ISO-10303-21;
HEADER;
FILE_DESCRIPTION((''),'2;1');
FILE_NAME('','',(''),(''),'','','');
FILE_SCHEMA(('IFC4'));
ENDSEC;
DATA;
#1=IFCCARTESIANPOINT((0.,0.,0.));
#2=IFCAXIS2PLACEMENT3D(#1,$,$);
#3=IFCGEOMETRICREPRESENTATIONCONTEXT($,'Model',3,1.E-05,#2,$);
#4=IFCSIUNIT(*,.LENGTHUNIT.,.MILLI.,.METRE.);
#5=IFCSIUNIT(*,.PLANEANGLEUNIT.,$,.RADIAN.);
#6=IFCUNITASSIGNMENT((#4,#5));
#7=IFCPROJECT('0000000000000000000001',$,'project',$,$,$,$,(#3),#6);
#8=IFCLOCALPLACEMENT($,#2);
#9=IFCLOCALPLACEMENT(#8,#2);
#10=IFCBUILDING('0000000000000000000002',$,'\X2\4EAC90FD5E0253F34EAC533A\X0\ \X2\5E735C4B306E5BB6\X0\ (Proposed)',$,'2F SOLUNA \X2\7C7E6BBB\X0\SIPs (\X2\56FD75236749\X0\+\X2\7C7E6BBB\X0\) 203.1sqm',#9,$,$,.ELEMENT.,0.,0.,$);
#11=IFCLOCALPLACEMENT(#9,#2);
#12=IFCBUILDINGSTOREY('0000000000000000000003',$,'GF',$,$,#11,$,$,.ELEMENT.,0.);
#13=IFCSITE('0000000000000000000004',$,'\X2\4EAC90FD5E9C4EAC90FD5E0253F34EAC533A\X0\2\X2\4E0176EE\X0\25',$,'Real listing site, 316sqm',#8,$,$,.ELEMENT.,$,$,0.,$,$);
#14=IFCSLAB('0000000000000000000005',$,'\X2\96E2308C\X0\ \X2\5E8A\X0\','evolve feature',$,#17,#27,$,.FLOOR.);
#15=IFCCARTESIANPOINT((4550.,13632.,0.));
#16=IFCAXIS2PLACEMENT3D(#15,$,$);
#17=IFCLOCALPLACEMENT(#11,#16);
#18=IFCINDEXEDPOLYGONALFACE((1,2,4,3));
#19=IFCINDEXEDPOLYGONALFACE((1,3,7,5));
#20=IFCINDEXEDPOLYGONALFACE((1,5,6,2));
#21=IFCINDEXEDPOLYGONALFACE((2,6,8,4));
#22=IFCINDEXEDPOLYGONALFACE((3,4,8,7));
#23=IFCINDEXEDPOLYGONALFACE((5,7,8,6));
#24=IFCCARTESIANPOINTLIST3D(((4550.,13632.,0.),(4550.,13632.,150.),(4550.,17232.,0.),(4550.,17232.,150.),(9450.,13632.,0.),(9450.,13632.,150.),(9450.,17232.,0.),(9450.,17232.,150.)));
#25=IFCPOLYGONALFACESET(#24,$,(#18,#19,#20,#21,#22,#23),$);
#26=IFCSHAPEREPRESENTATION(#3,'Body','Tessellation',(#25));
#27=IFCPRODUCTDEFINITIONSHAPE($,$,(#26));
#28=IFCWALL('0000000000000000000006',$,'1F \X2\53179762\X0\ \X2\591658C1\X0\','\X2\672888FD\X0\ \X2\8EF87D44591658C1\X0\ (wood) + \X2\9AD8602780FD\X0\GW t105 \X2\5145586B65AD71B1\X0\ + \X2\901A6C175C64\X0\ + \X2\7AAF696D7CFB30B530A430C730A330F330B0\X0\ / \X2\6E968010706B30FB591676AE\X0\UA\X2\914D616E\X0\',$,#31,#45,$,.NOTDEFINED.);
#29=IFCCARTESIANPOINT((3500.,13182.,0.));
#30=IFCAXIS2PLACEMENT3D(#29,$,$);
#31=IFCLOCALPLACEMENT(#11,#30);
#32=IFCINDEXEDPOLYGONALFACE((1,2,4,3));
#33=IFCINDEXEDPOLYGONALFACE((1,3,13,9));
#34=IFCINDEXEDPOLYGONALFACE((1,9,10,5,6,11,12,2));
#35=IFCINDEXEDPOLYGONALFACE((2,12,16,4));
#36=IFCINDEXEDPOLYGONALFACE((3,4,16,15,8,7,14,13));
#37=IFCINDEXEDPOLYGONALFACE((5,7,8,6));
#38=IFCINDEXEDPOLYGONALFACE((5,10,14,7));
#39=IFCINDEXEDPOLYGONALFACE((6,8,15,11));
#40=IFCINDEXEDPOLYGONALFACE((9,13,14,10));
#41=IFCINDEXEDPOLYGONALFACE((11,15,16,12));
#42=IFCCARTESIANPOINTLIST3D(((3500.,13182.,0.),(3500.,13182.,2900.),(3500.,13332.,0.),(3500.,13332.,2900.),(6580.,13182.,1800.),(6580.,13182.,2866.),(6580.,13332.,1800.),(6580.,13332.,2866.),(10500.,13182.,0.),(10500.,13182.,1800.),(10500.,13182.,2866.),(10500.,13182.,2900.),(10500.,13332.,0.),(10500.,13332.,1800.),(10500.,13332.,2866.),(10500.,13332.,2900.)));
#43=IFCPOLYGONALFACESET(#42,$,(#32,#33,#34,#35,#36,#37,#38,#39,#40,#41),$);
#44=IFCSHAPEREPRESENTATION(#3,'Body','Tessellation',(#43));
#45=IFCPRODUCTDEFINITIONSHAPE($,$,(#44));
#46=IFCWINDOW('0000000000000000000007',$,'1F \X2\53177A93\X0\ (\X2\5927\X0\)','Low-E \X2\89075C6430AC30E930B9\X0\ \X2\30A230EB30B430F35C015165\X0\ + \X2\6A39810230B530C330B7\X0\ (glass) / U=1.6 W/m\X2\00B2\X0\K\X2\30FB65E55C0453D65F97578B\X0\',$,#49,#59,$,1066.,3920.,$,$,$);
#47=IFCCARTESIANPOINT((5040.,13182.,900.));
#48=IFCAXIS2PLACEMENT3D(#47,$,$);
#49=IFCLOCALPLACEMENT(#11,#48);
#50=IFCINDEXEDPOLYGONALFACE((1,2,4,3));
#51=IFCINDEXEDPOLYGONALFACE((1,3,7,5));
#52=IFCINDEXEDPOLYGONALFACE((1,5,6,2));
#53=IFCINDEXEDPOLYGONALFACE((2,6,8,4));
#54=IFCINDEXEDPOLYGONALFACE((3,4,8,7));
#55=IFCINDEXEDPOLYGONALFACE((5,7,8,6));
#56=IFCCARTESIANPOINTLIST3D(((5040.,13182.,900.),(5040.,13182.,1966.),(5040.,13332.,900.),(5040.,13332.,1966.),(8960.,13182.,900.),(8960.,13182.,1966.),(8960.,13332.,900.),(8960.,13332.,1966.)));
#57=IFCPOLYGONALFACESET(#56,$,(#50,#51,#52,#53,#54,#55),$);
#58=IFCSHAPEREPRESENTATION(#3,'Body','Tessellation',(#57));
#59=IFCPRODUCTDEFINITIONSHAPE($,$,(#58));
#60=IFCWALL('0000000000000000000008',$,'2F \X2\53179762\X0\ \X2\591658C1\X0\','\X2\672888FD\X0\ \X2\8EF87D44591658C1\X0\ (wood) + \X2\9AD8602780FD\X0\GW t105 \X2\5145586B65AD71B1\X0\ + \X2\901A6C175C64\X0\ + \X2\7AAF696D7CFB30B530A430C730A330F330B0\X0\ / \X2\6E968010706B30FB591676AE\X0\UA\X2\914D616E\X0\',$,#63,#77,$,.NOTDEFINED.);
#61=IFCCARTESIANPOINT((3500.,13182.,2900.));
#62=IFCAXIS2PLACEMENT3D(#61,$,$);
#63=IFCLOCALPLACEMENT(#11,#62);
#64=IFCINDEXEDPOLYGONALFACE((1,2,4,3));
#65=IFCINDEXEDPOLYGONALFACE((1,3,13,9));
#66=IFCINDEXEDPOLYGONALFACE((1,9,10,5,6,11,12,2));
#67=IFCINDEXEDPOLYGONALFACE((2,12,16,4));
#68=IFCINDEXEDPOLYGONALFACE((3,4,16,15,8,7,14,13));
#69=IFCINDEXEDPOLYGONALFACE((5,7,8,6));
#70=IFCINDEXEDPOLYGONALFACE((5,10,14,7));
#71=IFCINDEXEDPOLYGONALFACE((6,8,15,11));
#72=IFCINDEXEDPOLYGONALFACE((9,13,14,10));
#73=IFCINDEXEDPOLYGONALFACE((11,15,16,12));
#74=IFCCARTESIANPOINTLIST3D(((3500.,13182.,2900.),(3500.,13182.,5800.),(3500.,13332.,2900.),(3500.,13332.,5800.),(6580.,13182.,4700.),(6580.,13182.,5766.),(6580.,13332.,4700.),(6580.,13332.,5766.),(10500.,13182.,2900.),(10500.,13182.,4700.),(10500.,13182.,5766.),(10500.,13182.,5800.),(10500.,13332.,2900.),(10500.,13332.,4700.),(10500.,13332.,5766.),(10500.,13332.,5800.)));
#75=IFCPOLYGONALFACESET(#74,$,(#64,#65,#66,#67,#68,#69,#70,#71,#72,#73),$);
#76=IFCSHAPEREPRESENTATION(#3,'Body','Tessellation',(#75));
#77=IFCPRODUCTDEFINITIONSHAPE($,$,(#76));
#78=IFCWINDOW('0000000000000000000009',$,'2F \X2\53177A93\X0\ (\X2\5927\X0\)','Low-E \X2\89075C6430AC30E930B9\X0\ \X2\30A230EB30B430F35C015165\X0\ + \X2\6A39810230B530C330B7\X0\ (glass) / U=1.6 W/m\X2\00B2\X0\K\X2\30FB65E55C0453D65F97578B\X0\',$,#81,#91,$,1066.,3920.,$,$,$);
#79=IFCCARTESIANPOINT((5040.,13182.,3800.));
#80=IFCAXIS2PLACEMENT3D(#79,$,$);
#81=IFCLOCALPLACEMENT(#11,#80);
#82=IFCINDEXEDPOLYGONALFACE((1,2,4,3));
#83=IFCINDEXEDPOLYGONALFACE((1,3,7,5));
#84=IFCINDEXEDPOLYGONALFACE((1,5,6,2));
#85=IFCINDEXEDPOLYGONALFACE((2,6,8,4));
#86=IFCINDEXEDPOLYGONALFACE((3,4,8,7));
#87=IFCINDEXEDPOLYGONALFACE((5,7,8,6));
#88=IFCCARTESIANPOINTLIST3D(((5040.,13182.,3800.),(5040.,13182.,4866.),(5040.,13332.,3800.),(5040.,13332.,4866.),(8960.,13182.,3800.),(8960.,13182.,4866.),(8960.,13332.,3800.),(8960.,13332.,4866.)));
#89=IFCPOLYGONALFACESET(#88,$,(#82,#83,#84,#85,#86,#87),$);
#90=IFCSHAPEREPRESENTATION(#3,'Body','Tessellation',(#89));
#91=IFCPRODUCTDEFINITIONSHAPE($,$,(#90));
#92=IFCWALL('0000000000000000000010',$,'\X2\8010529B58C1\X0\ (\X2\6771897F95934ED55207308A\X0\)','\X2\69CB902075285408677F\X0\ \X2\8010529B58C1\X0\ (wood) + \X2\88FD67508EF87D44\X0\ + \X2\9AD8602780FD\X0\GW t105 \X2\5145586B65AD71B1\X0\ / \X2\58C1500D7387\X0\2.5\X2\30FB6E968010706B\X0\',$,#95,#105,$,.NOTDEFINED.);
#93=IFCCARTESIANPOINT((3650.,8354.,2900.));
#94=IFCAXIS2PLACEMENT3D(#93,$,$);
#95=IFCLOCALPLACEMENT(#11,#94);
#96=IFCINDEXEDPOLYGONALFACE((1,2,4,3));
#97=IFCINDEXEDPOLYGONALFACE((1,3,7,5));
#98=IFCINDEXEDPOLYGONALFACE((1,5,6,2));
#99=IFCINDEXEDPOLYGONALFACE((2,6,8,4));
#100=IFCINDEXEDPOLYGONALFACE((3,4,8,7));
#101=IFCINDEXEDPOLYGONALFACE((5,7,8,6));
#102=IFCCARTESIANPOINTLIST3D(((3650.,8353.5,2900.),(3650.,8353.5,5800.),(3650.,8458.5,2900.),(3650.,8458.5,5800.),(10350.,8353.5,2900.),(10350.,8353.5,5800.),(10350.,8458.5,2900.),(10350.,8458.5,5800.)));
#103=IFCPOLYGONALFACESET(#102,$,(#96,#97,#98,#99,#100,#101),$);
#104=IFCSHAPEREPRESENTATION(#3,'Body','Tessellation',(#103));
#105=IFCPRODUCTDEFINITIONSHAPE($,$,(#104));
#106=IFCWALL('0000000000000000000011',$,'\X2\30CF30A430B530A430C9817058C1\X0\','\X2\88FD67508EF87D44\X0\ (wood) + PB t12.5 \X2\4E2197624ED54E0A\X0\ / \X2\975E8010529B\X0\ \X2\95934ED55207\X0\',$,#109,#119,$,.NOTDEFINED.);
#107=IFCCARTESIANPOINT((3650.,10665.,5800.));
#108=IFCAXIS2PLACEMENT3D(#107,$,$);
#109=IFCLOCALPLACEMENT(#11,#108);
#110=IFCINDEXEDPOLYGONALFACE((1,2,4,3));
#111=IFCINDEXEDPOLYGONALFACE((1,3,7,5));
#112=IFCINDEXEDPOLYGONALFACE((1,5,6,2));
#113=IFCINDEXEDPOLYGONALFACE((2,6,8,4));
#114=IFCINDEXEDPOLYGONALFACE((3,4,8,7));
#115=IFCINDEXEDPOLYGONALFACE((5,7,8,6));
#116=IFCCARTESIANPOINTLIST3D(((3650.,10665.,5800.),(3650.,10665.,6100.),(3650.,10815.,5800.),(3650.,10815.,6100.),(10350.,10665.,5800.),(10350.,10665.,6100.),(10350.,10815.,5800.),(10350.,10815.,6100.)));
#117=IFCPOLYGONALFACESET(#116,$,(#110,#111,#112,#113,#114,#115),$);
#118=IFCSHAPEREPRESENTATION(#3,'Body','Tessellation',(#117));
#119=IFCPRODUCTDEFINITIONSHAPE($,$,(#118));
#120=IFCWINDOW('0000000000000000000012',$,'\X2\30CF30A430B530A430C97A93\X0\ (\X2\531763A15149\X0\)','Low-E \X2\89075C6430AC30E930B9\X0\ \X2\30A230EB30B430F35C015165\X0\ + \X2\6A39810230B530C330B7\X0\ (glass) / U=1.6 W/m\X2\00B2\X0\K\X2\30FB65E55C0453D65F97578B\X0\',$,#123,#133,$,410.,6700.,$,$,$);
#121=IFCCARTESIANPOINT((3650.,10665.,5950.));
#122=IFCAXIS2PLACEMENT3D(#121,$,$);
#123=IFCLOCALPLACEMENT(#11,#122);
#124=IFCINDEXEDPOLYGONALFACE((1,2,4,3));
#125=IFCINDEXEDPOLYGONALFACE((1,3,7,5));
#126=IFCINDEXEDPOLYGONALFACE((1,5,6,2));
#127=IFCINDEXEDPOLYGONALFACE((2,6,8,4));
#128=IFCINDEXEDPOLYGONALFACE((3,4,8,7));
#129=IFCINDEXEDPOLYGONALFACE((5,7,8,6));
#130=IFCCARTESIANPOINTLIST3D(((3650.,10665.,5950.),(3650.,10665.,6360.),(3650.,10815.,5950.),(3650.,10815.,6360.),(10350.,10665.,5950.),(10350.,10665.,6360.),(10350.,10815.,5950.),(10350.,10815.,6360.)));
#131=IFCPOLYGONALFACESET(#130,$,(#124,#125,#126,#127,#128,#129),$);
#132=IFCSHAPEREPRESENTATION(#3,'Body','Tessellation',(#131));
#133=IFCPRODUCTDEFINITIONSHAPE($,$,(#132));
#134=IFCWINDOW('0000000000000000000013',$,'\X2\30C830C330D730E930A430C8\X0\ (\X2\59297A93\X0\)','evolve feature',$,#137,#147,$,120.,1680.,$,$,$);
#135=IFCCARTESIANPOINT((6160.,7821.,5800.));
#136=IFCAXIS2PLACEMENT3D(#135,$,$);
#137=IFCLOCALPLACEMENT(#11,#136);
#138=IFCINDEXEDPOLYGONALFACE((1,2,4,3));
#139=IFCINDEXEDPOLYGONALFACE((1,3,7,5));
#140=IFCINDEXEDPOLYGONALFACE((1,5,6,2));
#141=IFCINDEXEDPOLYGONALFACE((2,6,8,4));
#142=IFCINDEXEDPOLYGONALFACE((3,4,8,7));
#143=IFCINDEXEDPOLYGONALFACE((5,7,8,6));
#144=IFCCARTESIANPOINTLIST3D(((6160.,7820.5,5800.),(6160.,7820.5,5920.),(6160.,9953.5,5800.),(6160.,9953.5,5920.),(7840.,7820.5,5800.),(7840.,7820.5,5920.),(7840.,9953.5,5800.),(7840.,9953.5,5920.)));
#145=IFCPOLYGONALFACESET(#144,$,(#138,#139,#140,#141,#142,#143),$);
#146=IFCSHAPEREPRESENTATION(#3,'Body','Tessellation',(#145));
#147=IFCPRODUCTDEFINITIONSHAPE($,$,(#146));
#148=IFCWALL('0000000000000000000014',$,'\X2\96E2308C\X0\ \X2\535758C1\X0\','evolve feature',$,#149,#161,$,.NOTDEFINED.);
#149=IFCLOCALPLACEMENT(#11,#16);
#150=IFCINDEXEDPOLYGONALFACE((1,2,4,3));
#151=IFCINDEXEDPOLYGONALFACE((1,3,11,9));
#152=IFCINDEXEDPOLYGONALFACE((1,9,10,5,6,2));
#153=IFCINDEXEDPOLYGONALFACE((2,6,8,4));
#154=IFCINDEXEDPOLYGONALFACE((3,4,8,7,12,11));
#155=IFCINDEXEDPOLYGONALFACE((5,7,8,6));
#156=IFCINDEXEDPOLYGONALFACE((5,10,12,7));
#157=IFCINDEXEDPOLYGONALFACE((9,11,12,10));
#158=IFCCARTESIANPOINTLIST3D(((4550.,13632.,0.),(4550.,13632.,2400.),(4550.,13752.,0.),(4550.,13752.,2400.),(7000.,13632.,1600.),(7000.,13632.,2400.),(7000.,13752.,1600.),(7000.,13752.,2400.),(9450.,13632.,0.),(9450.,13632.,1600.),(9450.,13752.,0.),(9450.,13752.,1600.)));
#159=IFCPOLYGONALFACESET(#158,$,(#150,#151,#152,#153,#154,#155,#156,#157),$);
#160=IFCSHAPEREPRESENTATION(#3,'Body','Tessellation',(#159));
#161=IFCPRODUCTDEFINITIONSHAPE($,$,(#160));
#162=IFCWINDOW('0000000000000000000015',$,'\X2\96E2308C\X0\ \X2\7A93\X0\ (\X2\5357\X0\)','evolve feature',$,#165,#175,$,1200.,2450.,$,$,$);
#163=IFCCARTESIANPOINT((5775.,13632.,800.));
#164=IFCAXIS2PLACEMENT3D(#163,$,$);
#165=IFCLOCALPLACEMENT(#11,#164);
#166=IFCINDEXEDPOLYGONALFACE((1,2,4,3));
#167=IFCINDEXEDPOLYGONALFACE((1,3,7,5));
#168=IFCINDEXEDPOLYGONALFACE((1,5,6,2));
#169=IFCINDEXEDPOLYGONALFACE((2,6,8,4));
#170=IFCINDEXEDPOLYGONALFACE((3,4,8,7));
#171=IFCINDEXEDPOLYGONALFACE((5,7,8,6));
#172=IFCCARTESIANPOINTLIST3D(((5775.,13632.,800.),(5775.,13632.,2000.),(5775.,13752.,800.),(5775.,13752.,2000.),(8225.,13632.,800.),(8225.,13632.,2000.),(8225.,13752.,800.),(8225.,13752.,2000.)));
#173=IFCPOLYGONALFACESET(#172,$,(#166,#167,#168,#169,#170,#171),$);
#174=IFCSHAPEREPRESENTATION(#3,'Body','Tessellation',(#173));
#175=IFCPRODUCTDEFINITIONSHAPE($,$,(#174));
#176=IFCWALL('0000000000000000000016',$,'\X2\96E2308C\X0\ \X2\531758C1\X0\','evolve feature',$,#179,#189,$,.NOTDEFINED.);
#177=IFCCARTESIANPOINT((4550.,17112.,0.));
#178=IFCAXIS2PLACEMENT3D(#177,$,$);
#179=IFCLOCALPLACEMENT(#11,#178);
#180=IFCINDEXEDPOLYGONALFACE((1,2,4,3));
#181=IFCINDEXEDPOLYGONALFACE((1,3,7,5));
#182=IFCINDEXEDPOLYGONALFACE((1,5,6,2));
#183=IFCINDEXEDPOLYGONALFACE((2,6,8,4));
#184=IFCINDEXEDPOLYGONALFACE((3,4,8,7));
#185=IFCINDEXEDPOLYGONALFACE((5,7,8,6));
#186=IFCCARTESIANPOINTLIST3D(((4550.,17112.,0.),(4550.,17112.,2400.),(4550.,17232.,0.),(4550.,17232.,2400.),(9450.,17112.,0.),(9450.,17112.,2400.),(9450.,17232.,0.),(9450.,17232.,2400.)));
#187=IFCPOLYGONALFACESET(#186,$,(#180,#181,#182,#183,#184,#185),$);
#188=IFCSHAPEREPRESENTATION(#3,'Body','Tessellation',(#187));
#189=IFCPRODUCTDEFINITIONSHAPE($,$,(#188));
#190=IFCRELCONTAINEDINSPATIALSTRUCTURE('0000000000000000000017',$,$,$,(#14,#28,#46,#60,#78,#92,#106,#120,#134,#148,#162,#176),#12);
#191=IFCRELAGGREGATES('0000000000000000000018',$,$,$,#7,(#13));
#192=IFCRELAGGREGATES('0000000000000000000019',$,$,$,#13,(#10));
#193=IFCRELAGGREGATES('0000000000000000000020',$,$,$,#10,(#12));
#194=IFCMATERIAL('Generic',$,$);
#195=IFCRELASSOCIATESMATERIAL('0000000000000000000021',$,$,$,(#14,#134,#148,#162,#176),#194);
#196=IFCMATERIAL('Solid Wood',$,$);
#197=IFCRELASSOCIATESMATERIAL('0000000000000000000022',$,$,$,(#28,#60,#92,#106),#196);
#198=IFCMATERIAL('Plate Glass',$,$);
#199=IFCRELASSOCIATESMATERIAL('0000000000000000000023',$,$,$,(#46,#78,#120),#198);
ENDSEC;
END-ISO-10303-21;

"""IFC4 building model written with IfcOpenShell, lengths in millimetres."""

from ifc_helpers import new_model, si_unit, frame, frame_2d, origin, place, context, project, spatial, rectangle, extrude, material, element, fill, save


model = new_model("IFC4")

# Units and contexts
model_context = context("Model", 3, precision=1e-05, world=origin())
ifc_project = project(units=[si_unit("LENGTHUNIT", "METRE", prefix="MILLI"), si_unit("PLANEANGLEUNIT", "RADIAN")], contexts=[model_context])

# Site, building, storey
site_placement = place(None, origin())
site = spatial("IfcSite", under=ifc_project, at=site_placement, Name="京都府京都市右京区2丁目25", ObjectType="Real listing site, 316sqm", CompositionType="ELEMENT", RefElevation=0.0)
building_placement = place(site_placement, origin())
building = spatial("IfcBuilding", under=site, at=building_placement, Name="京都市右京区 平屋の家 (Proposed)", ObjectType="2F SOLUNA 籾殻SIPs (国産杉+籾殻) 203.1sqm", CompositionType="ELEMENT", ElevationOfRefHeight=0.0, ElevationOfTerrain=0.0)
storey_placement = place(building_placement, origin())
storey = spatial("IfcBuildingStorey", under=building, at=storey_placement, Name="GF", CompositionType="ELEMENT", Elevation=0.0)

# Slab
ifc_material_1 = material(Name="Generic")
slab_placement = place(storey_placement, frame((4550.0, 13632.0, 0.0)))
element("IfcSlab", 1, at=slab_placement, inside=storey, material=ifc_material_1, Name="離れ 床", Description="evolve feature", PredefinedType="FLOOR", context=model_context, shape_type="SweptSolid", body=[
    extrude(rectangle(XDim=4900.0, YDim=3600.0, at=frame_2d((2450.0, 1800.0))), frame((4550.0, 13632.0, 0.0)), (0.0, 0.0, 1.0), 150.0),
])

# Wall, opening, window
ifc_material_2 = material(Name="Solid Wood")
wall_1_placement = place(storey_placement, frame((3500.0, 13182.0, 0.0)))
wall_1 = element("IfcWall", 2, at=wall_1_placement, inside=storey, material=ifc_material_2, Name="1F 北面 外壁", Description="木製 軸組外壁 (wood) + 高性能GW t105 充填断熱 + 通気層 + 窯業系サイディング / 準耐火・外皮UA配慮", PredefinedType="NOTDEFINED", context=model_context, shape_type="SweptSolid", body=[
    extrude(rectangle(XDim=7000.0, YDim=150.0, at=frame_2d((3500.0, 75.0))), frame((3500.0, 13182.0, 0.0)), (0.0, 0.0, 1.0), 2900.0),
])
opening_1_placement = place(storey_placement, frame((5040.0, 13182.0, 900.0)))
opening_1 = element("IfcOpeningElement", 3, at=opening_1_placement, cuts=wall_1, PredefinedType="NOTDEFINED", context=model_context, shape_type="SweptSolid", body=[
    extrude(rectangle(XDim=3920.0, YDim=150.0, at=frame_2d((1960.0, 75.0))), frame((5040.0, 13182.0, 900.0)), (0.0, 0.0, 1.0), 1066.0),
])
ifc_material_3 = material(Name="Plate Glass")
window_1_placement = place(storey_placement, frame((5040.0, 13182.0, 900.0)))
window_1 = element("IfcWindow", 4, at=window_1_placement, inside=storey, material=ifc_material_3, Name="1F 北窓 (大)", Description="Low-E 複層ガラス アルゴン封入 + 樹脂サッシ (glass) / U=1.6 W/m²K・日射取得型", OverallHeight=1066.0, OverallWidth=3920.0, context=model_context, shape_type="SweptSolid", body=[
    extrude(rectangle(XDim=3920.0, YDim=150.0, at=frame_2d((1960.0, 75.0))), frame((5040.0, 13182.0, 900.0)), (0.0, 0.0, 1.0), 1066.0),
])
fill(opening_1, window_1)

# Wall, opening, window
wall_2_placement = place(storey_placement, frame((3500.0, 13182.0, 2900.0)))
wall_2 = element("IfcWall", 5, at=wall_2_placement, inside=storey, material=ifc_material_2, Name="2F 北面 外壁", Description="木製 軸組外壁 (wood) + 高性能GW t105 充填断熱 + 通気層 + 窯業系サイディング / 準耐火・外皮UA配慮", PredefinedType="NOTDEFINED", context=model_context, shape_type="SweptSolid", body=[
    extrude(rectangle(XDim=7000.0, YDim=150.0, at=frame_2d((3500.0, 75.0))), frame((3500.0, 13182.0, 2900.0)), (0.0, 0.0, 1.0), 2900.0),
])
opening_2_placement = place(storey_placement, frame((5040.0, 13182.0, 3800.0)))
opening_2 = element("IfcOpeningElement", 6, at=opening_2_placement, cuts=wall_2, PredefinedType="NOTDEFINED", context=model_context, shape_type="SweptSolid", body=[
    extrude(rectangle(XDim=3920.0, YDim=150.0, at=frame_2d((1960.0, 75.0))), frame((5040.0, 13182.0, 3800.0)), (0.0, 0.0, 1.0), 1066.0),
])
window_2_placement = place(storey_placement, frame((5040.0, 13182.0, 3800.0)))
window_2 = element("IfcWindow", 7, at=window_2_placement, inside=storey, material=ifc_material_3, Name="2F 北窓 (大)", Description="Low-E 複層ガラス アルゴン封入 + 樹脂サッシ (glass) / U=1.6 W/m²K・日射取得型", OverallHeight=1066.0, OverallWidth=3920.0, context=model_context, shape_type="SweptSolid", body=[
    extrude(rectangle(XDim=3920.0, YDim=150.0, at=frame_2d((1960.0, 75.0))), frame((5040.0, 13182.0, 3800.0)), (0.0, 0.0, 1.0), 1066.0),
])
fill(opening_2, window_2)

# Wall
wall_3_placement = place(storey_placement, frame((3650.0, 8354.0, 2900.0)))
element("IfcWall", 8, at=wall_3_placement, inside=storey, material=ifc_material_2, Name="耐力壁 (東西間仕切り)", Description="構造用合板 耐力壁 (wood) + 製材軸組 + 高性能GW t105 充填断熱 / 壁倍率2.5・準耐火", PredefinedType="NOTDEFINED", context=model_context, shape_type="SweptSolid", body=[
    extrude(rectangle(XDim=6700.0, YDim=105.0, at=frame_2d((3350.0, 52.0))), frame((3650.0, 8354.0, 2900.0)), (0.0, 0.0, 1.0), 2900.0),
])

# Wall, opening, window
wall_4_placement = place(storey_placement, frame((3650.0, 10665.0, 5800.0)))
wall_4 = element("IfcWall", 9, at=wall_4_placement, inside=storey, material=ifc_material_2, Name="ハイサイド腰壁", Description="製材軸組 (wood) + PB t12.5 両面仕上 / 非耐力 間仕切", PredefinedType="NOTDEFINED", context=model_context, shape_type="SweptSolid", body=[
    extrude(rectangle(XDim=6700.0, YDim=150.0, at=frame_2d((3350.0, 75.0))), frame((3650.0, 10665.0, 5800.0)), (0.0, 0.0, 1.0), 700.0),
])
opening_3_placement = place(storey_placement, frame((3650.0, 10665.0, 5950.0)))
opening_3 = element("IfcOpeningElement", 10, at=opening_3_placement, cuts=wall_4, PredefinedType="NOTDEFINED", context=model_context, shape_type="SweptSolid", body=[
    extrude(rectangle(XDim=6700.0, YDim=150.0, at=frame_2d((3350.0, 75.0))), frame((3650.0, 10665.0, 5950.0)), (0.0, 0.0, 1.0), 410.0),
])
window_3_placement = place(storey_placement, frame((3650.0, 10665.0, 5950.0)))
window_3 = element("IfcWindow", 11, at=window_3_placement, inside=storey, material=ifc_material_3, Name="ハイサイド窓 (北採光)", Description="Low-E 複層ガラス アルゴン封入 + 樹脂サッシ (glass) / U=1.6 W/m²K・日射取得型", OverallHeight=410.0, OverallWidth=6700.0, context=model_context, shape_type="SweptSolid", body=[
    extrude(rectangle(XDim=6700.0, YDim=150.0, at=frame_2d((3350.0, 75.0))), frame((3650.0, 10665.0, 5950.0)), (0.0, 0.0, 1.0), 410.0),
])
fill(opening_3, window_3)

# Window
window_4_placement = place(storey_placement, frame((6160.0, 7821.0, 5800.0)))
element("IfcWindow", 12, at=window_4_placement, inside=storey, material=ifc_material_1, Name="トップライト (天窓)", Description="evolve feature", OverallHeight=120.0, OverallWidth=1680.0, context=model_context, shape_type="SweptSolid", body=[
    extrude(rectangle(XDim=1680.0, YDim=2133.0, at=frame_2d((840.0, 1066.0))), frame((6160.0, 7821.0, 5800.0)), (0.0, 0.0, 1.0), 120.0),
])

# Wall, opening, window
wall_5_placement = place(storey_placement, frame((4550.0, 13632.0, 0.0)))
wall_5 = element("IfcWall", 13, at=wall_5_placement, inside=storey, material=ifc_material_1, Name="離れ 南壁", Description="evolve feature", PredefinedType="NOTDEFINED", context=model_context, shape_type="SweptSolid", body=[
    extrude(rectangle(XDim=4900.0, YDim=120.0, at=frame_2d((2450.0, 60.0))), frame((4550.0, 13632.0, 0.0)), (0.0, 0.0, 1.0), 2400.0),
])
opening_4_placement = place(storey_placement, frame((5775.0, 13632.0, 800.0)))
opening_4 = element("IfcOpeningElement", 14, at=opening_4_placement, cuts=wall_5, PredefinedType="NOTDEFINED", context=model_context, shape_type="SweptSolid", body=[
    extrude(rectangle(XDim=2450.0, YDim=120.0, at=frame_2d((1225.0, 60.0))), frame((5775.0, 13632.0, 800.0)), (0.0, 0.0, 1.0), 1200.0),
])
window_5_placement = place(storey_placement, frame((5775.0, 13632.0, 800.0)))
window_5 = element("IfcWindow", 15, at=window_5_placement, inside=storey, material=ifc_material_1, Name="離れ 窓 (南)", Description="evolve feature", OverallHeight=1200.0, OverallWidth=2450.0, context=model_context, shape_type="SweptSolid", body=[
    extrude(rectangle(XDim=2450.0, YDim=120.0, at=frame_2d((1225.0, 60.0))), frame((5775.0, 13632.0, 800.0)), (0.0, 0.0, 1.0), 1200.0),
])
fill(opening_4, window_5)

# Wall
wall_6_placement = place(storey_placement, frame((4550.0, 17112.0, 0.0)))
element("IfcWall", 16, at=wall_6_placement, inside=storey, material=ifc_material_1, Name="離れ 北壁", Description="evolve feature", PredefinedType="NOTDEFINED", context=model_context, shape_type="SweptSolid", body=[
    extrude(rectangle(XDim=4900.0, YDim=120.0, at=frame_2d((2450.0, 60.0))), frame((4550.0, 17112.0, 0.0)), (0.0, 0.0, 1.0), 2400.0),
])

save(model, "model.ifc")
